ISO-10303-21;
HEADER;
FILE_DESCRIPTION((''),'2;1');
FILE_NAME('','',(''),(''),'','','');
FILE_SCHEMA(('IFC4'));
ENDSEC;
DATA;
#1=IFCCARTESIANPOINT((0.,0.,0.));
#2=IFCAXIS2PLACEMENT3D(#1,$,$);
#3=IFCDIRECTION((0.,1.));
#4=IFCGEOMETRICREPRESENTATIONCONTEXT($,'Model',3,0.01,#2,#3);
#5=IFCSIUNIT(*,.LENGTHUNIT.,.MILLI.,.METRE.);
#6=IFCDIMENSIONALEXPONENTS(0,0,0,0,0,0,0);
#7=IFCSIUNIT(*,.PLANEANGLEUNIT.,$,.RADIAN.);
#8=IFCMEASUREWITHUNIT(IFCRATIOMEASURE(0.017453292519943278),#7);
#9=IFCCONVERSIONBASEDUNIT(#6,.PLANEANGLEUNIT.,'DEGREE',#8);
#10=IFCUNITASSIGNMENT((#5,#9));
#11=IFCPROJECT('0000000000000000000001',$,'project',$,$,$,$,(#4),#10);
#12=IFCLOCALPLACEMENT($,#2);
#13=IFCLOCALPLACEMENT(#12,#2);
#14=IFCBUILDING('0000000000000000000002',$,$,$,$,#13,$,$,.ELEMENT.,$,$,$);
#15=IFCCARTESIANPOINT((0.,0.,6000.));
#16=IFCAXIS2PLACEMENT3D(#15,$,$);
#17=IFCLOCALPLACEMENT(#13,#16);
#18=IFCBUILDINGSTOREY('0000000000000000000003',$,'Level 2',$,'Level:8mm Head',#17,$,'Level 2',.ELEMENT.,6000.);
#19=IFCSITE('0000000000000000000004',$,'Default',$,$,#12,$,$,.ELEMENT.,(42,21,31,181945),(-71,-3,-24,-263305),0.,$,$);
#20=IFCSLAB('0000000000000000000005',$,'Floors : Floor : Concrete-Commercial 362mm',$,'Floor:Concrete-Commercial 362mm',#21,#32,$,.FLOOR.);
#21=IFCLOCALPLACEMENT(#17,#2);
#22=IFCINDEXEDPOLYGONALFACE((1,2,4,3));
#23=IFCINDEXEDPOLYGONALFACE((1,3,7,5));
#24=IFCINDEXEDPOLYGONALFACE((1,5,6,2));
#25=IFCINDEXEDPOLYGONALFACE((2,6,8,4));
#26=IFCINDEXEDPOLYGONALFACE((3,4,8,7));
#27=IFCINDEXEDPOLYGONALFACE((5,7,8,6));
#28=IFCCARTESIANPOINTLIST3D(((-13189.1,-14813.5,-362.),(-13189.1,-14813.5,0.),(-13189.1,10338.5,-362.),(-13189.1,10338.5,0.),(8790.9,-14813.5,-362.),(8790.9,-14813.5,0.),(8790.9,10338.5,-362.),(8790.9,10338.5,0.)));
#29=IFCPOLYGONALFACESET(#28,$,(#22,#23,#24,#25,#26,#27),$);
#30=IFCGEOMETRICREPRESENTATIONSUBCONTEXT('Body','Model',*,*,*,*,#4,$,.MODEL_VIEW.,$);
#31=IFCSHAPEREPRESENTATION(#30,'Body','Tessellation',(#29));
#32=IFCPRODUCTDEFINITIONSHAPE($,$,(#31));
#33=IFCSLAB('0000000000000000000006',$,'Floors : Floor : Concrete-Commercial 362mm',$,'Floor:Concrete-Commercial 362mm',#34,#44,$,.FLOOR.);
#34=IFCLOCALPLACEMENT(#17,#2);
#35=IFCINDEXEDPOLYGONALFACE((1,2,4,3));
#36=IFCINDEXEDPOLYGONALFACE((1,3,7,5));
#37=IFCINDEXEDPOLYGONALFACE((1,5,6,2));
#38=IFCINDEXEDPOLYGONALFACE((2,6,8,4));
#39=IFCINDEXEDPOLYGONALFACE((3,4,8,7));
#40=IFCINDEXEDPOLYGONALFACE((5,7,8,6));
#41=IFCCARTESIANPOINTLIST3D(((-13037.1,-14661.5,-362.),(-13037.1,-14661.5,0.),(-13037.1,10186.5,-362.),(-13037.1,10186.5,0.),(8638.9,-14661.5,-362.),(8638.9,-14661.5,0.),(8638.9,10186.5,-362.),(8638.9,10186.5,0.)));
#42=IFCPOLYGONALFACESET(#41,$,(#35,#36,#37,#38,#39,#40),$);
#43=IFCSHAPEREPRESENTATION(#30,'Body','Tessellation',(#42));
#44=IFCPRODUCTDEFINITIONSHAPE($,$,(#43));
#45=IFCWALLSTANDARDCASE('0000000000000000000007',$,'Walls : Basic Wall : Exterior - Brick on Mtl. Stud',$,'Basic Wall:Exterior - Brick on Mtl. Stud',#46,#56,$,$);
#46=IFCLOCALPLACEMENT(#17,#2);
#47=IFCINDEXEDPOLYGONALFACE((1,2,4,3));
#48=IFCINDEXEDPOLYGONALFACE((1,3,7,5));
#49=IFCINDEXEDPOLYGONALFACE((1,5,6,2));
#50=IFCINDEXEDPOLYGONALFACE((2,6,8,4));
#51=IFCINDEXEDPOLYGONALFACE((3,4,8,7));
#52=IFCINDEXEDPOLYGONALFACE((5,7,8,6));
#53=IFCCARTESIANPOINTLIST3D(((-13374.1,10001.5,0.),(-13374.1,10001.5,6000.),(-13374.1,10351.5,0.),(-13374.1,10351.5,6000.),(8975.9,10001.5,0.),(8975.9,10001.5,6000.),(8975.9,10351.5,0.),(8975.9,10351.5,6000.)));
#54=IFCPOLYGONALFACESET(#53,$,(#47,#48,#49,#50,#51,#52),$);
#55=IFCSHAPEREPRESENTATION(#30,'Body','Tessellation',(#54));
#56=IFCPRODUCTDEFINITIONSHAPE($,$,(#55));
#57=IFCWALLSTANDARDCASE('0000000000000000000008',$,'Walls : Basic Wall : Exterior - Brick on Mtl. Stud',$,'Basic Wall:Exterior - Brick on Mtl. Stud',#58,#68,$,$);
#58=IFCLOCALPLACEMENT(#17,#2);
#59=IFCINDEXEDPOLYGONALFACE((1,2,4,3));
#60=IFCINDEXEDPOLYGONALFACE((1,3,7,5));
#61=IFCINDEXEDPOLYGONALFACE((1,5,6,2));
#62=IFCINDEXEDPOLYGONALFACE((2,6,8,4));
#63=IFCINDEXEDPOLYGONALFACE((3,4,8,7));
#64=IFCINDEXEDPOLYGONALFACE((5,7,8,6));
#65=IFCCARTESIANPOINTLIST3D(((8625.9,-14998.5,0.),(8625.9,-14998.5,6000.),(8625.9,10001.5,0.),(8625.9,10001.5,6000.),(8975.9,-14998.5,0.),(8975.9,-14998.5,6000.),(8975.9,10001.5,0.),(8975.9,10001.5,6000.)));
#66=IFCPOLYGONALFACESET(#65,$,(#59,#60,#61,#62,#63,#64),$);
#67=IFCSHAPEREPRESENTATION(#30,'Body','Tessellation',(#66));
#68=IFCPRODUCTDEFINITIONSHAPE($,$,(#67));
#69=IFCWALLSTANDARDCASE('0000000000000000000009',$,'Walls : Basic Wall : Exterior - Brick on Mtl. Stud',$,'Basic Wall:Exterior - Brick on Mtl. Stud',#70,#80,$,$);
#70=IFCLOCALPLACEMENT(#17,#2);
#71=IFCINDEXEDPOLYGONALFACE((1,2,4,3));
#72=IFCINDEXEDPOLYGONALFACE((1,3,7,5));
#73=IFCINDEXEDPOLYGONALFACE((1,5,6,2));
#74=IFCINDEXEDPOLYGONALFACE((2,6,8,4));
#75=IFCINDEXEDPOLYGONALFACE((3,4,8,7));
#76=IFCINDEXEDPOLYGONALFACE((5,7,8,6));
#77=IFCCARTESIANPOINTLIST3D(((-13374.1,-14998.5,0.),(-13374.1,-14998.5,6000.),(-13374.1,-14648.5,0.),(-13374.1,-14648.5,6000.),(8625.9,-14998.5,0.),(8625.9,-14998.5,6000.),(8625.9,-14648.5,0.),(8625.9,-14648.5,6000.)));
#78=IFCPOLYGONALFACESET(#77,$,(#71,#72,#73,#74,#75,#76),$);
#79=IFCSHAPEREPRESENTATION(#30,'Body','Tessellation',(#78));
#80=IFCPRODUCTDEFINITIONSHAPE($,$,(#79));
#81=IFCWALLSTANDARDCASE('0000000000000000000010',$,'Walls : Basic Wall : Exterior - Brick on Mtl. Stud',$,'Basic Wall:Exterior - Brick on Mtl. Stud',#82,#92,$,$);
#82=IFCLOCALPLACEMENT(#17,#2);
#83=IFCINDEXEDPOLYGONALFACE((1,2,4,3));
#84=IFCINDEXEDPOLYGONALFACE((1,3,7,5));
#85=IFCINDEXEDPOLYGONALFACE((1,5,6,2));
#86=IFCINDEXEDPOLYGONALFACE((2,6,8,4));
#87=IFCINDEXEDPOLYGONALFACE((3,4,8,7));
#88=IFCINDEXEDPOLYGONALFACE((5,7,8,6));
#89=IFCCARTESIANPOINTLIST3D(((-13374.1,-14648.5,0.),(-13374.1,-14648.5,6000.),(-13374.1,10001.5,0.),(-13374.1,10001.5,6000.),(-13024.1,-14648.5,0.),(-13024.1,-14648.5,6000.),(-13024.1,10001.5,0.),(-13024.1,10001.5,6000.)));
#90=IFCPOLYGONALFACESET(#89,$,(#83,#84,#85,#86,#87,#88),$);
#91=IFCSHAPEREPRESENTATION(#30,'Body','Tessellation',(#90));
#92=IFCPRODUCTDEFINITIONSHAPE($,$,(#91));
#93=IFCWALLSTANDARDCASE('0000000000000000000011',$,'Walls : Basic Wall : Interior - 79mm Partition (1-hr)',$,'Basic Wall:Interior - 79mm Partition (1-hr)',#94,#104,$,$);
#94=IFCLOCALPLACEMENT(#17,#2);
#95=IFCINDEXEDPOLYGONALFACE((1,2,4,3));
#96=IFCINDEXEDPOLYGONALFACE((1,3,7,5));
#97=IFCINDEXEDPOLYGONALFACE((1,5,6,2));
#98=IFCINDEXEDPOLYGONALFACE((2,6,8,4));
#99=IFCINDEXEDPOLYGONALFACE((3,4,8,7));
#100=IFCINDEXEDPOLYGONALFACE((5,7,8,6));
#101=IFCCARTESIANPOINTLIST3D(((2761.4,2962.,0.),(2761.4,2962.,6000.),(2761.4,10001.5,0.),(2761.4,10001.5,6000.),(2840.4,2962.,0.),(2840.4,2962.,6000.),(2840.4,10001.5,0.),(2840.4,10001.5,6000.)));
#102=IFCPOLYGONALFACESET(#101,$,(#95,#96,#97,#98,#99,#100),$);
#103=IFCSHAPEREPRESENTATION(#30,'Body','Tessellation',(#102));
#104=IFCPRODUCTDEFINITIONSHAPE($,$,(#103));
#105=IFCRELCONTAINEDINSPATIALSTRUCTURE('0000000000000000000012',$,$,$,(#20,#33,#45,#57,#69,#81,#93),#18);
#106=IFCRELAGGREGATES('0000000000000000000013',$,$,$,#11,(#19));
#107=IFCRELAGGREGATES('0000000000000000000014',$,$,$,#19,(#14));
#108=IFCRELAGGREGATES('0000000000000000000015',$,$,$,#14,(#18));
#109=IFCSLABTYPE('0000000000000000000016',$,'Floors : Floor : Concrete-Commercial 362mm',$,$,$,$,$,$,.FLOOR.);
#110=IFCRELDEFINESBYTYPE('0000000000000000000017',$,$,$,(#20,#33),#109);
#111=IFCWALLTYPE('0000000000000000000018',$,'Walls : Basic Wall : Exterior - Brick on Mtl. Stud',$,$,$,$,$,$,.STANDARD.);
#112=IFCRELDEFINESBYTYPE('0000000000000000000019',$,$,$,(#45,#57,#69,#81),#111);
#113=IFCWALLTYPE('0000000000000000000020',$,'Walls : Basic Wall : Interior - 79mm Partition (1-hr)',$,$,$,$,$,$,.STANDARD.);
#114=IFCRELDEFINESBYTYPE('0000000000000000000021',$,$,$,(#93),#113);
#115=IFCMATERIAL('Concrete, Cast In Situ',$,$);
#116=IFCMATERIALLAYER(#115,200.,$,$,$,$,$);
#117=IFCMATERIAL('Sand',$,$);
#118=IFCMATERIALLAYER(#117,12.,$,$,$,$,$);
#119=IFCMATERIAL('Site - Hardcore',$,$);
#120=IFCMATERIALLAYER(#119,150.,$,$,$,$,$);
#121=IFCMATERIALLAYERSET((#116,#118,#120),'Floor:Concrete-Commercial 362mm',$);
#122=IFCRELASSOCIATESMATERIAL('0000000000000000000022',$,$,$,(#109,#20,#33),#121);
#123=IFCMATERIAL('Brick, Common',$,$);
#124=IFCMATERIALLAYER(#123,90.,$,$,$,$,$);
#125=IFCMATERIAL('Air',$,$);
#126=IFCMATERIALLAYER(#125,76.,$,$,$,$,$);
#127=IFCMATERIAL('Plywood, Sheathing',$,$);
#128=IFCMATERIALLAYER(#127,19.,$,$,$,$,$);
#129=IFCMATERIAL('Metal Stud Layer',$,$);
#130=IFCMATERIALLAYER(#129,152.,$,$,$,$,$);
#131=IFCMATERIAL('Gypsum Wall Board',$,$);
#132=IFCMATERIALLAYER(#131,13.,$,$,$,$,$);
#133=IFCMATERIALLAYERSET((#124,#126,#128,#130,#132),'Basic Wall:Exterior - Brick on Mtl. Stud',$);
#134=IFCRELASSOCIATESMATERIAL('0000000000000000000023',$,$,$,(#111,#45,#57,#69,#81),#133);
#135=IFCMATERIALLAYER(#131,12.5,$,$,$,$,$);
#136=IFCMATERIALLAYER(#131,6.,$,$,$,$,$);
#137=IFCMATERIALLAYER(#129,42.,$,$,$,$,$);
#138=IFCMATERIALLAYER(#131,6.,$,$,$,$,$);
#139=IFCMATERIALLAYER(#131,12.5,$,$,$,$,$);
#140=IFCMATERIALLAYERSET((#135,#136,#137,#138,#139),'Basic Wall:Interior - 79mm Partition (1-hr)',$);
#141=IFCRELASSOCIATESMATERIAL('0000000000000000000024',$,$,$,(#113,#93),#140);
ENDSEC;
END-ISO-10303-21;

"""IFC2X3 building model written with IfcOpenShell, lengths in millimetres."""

from ifc_helpers import new_model, entity, si_unit, converted_unit, direction, frame, frame_2d, origin, place, context, subcontext, project, spatial, rectangle, extrude, clip, halfspace, material, layer, layer_set, layer_usage, type_object, element, save


model = new_model("IFC2X3")

# Units and contexts
model_context = context("Model", 3, precision=0.01, world=origin(), true_north=direction((0.0, 1.0)))
body_context = subcontext(model_context, "Body", "Model", "MODEL_VIEW")
ifc_project = project(units=[si_unit("LENGTHUNIT", "METRE", prefix="MILLI"), converted_unit("PLANEANGLEUNIT", "DEGREE", entity("IfcRatioMeasure", 0.017453292519943278), si_unit("PLANEANGLEUNIT", "RADIAN"), dimensions=[0, 0, 0, 0, 0, 0, 0])], contexts=[model_context])

# Site, building, storey
site_placement = place(None, origin())
site = spatial("IfcSite", under=ifc_project, at=site_placement, Name="Default", CompositionType="ELEMENT", RefLatitude=(42, 21, 31, 181945), RefLongitude=(-71, -3, -24, -263305), RefElevation=0.0)
building_placement = place(site_placement, origin())
building = spatial("IfcBuilding", under=site, at=building_placement, CompositionType="ELEMENT")
storey_placement = place(building_placement, frame((0.0, 0.0, 6000.0)))
storey = spatial("IfcBuildingStorey", under=building, at=storey_placement, Name="Level 2", ObjectType="Level:8mm Head", LongName="Level 2", CompositionType="ELEMENT", Elevation=6000.0)

# Slabs
ifc_material_1 = material(Name="Concrete, Cast In Situ")
ifc_layer_1 = layer(ifc_material_1, 200.0)
ifc_material_2 = material(Name="Sand")
ifc_layer_2 = layer(ifc_material_2, 12.0)
ifc_material_3 = material(Name="Site - Hardcore")
ifc_layer_3 = layer(ifc_material_3, 150.0)
ifc_layer_set_1 = layer_set([ifc_layer_1, ifc_layer_2, ifc_layer_3], Name="Floor:Concrete-Commercial 362mm")
ifc_layer_usage_1 = layer_usage(ifc_layer_set_1, "AXIS3", "POSITIVE", 0.0)
slab_type = type_object("IfcSlabType", Name="Floors : Floor : Concrete-Commercial 362mm", PredefinedType="FLOOR", material=ifc_layer_set_1)
slab_1_placement = place(storey_placement, origin())
element("IfcSlab", 1, at=slab_1_placement, inside=storey, type_object=slab_type, material=ifc_layer_usage_1, Name="Floors : Floor : Concrete-Commercial 362mm", ObjectType="Floor:Concrete-Commercial 362mm", PredefinedType="FLOOR", context=body_context, shape_type="SweptSolid", body=[
    extrude(rectangle(XDim=25152.0, YDim=21980.0, at=frame_2d((0.0, 0.0), x_axis=(1.0, 0.0))), frame((-2199.1, -2237.5, 0.0), z_axis=(0.0, 0.0, -1.0), x_axis=(0.0, 1.0, 0.0)), (0.0, 0.0, 1.0), 362.0),
])
slab_2_placement = place(storey_placement, origin())
element("IfcSlab", 2, at=slab_2_placement, inside=storey, type_object=slab_type, material=ifc_layer_usage_1, Name="Floors : Floor : Concrete-Commercial 362mm", ObjectType="Floor:Concrete-Commercial 362mm", PredefinedType="FLOOR", context=body_context, shape_type="SweptSolid", body=[
    extrude(rectangle(XDim=24848.0, YDim=21676.0, at=frame_2d((0.0, 0.0), x_axis=(1.0, 0.0))), frame((-2199.1, -2237.5, 0.0), z_axis=(0.0, 0.0, -1.0), x_axis=(0.0, 1.0, 0.0)), (0.0, 0.0, 1.0), 362.0),
])

# Walls
ifc_material_4 = material(Name="Brick, Common")
ifc_layer_4 = layer(ifc_material_4, 90.0)
ifc_material_5 = material(Name="Air")
ifc_layer_5 = layer(ifc_material_5, 76.0)
ifc_material_6 = material(Name="Plywood, Sheathing")
ifc_layer_6 = layer(ifc_material_6, 19.0)
ifc_material_7 = material(Name="Metal Stud Layer")
ifc_layer_7 = layer(ifc_material_7, 152.0)
ifc_material_8 = material(Name="Gypsum Wall Board")
ifc_layer_8 = layer(ifc_material_8, 13.0)
ifc_layer_set_2 = layer_set([ifc_layer_4, ifc_layer_5, ifc_layer_6, ifc_layer_7, ifc_layer_8], Name="Basic Wall:Exterior - Brick on Mtl. Stud")
ifc_layer_usage_2 = layer_usage(ifc_layer_set_2, "AXIS2", "POSITIVE", -175.0)
wall_type_1 = type_object("IfcWallType", Name="Walls : Basic Wall : Exterior - Brick on Mtl. Stud", PredefinedType="STANDARD", material=ifc_layer_set_2)
wall_1_placement = place(storey_placement, frame((-13374.1, 10176.5, 0.0)))
element("IfcWallStandardCase", 3, at=wall_1_placement, inside=storey, type_object=wall_type_1, material=ifc_layer_usage_2, Name="Walls : Basic Wall : Exterior - Brick on Mtl. Stud", ObjectType="Basic Wall:Exterior - Brick on Mtl. Stud", context=body_context, shape_type="Clipping", body=[
    clip(extrude(rectangle(XDim=22350.0, YDim=350.0, at=frame_2d((11175.0, 0.0), x_axis=(-1.0, 0.0))), origin(), (0.0, 0.0, 1.0), 6000.0), halfspace(frame((0.0, 0.0, -6000.0)), True)),
])
ifc_layer_usage_3 = layer_usage(ifc_layer_set_2, "AXIS2", "NEGATIVE", 175.0)
wall_2_placement = place(storey_placement, frame((8800.9, 10001.5, 0.0), z_axis=(0.0, 0.0, 1.0), x_axis=(0.0, -1.0, 0.0)))
element("IfcWallStandardCase", 4, at=wall_2_placement, inside=storey, type_object=wall_type_1, material=ifc_layer_usage_3, Name="Walls : Basic Wall : Exterior - Brick on Mtl. Stud", ObjectType="Basic Wall:Exterior - Brick on Mtl. Stud", context=body_context, shape_type="Clipping", body=[
    clip(extrude(rectangle(XDim=25000.0, YDim=350.0, at=frame_2d((12500.0, 0.0), x_axis=(1.0, 0.0))), origin(), (0.0, 0.0, 1.0), 6000.0), halfspace(frame((0.0, 0.0, -6000.0)), True)),
])
wall_3_placement = place(storey_placement, frame((8625.9, -14823.5, 0.0), z_axis=(0.0, 0.0, 1.0), x_axis=(-1.0, 0.0, 0.0)))
element("IfcWallStandardCase", 5, at=wall_3_placement, inside=storey, type_object=wall_type_1, material=ifc_layer_usage_3, Name="Walls : Basic Wall : Exterior - Brick on Mtl. Stud", ObjectType="Basic Wall:Exterior - Brick on Mtl. Stud", context=body_context, shape_type="Clipping", body=[
    clip(extrude(rectangle(XDim=22000.0, YDim=350.0, at=frame_2d((11000.0, 0.0), x_axis=(-1.0, 0.0))), origin(), (0.0, 0.0, 1.0), 6000.0), halfspace(frame((0.0, 0.0, -6000.0)), True)),
])
wall_4_placement = place(storey_placement, frame((-13199.1, -14648.5, 0.0), z_axis=(0.0, 0.0, 1.0), x_axis=(0.0, 1.0, 0.0)))
element("IfcWallStandardCase", 6, at=wall_4_placement, inside=storey, type_object=wall_type_1, material=ifc_layer_usage_3, Name="Walls : Basic Wall : Exterior - Brick on Mtl. Stud", ObjectType="Basic Wall:Exterior - Brick on Mtl. Stud", context=body_context, shape_type="Clipping", body=[
    clip(extrude(rectangle(XDim=24650.0, YDim=350.0, at=frame_2d((12325.0, 0.0), x_axis=(-1.0, 0.0))), origin(), (0.0, 0.0, 1.0), 6000.0), halfspace(frame((0.0, 0.0, -6000.0)), True)),
])
ifc_layer_9 = layer(ifc_material_8, 12.5)
ifc_layer_10 = layer(ifc_material_8, 6.0)
ifc_layer_11 = layer(ifc_material_7, 42.0)
ifc_layer_12 = layer(ifc_material_8, 6.0)
ifc_layer_13 = layer(ifc_material_8, 12.5)
ifc_layer_set_3 = layer_set([ifc_layer_9, ifc_layer_10, ifc_layer_11, ifc_layer_12, ifc_layer_13], Name="Basic Wall:Interior - 79mm Partition (1-hr)")
ifc_layer_usage_4 = layer_usage(ifc_layer_set_3, "AXIS2", "NEGATIVE", 39.5)
wall_type_2 = type_object("IfcWallType", Name="Walls : Basic Wall : Interior - 79mm Partition (1-hr)", PredefinedType="STANDARD", material=ifc_layer_set_3)
wall_5_placement = place(storey_placement, frame((2800.9, 10001.5, 0.0), z_axis=(0.0, 0.0, 1.0), x_axis=(0.0, -1.0, 0.0)))
element("IfcWallStandardCase", 7, at=wall_5_placement, inside=storey, type_object=wall_type_2, material=ifc_layer_usage_4, Name="Walls : Basic Wall : Interior - 79mm Partition (1-hr)", ObjectType="Basic Wall:Interior - 79mm Partition (1-hr)", context=body_context, shape_type="SweptSolid", body=[
    extrude(rectangle(XDim=7039.5, YDim=79.0, at=frame_2d((3519.8, 0.0), x_axis=(-1.0, 0.0))), origin(), (0.0, 0.0, 1.0), 6000.0),
])

save(model, "model.ifc")
